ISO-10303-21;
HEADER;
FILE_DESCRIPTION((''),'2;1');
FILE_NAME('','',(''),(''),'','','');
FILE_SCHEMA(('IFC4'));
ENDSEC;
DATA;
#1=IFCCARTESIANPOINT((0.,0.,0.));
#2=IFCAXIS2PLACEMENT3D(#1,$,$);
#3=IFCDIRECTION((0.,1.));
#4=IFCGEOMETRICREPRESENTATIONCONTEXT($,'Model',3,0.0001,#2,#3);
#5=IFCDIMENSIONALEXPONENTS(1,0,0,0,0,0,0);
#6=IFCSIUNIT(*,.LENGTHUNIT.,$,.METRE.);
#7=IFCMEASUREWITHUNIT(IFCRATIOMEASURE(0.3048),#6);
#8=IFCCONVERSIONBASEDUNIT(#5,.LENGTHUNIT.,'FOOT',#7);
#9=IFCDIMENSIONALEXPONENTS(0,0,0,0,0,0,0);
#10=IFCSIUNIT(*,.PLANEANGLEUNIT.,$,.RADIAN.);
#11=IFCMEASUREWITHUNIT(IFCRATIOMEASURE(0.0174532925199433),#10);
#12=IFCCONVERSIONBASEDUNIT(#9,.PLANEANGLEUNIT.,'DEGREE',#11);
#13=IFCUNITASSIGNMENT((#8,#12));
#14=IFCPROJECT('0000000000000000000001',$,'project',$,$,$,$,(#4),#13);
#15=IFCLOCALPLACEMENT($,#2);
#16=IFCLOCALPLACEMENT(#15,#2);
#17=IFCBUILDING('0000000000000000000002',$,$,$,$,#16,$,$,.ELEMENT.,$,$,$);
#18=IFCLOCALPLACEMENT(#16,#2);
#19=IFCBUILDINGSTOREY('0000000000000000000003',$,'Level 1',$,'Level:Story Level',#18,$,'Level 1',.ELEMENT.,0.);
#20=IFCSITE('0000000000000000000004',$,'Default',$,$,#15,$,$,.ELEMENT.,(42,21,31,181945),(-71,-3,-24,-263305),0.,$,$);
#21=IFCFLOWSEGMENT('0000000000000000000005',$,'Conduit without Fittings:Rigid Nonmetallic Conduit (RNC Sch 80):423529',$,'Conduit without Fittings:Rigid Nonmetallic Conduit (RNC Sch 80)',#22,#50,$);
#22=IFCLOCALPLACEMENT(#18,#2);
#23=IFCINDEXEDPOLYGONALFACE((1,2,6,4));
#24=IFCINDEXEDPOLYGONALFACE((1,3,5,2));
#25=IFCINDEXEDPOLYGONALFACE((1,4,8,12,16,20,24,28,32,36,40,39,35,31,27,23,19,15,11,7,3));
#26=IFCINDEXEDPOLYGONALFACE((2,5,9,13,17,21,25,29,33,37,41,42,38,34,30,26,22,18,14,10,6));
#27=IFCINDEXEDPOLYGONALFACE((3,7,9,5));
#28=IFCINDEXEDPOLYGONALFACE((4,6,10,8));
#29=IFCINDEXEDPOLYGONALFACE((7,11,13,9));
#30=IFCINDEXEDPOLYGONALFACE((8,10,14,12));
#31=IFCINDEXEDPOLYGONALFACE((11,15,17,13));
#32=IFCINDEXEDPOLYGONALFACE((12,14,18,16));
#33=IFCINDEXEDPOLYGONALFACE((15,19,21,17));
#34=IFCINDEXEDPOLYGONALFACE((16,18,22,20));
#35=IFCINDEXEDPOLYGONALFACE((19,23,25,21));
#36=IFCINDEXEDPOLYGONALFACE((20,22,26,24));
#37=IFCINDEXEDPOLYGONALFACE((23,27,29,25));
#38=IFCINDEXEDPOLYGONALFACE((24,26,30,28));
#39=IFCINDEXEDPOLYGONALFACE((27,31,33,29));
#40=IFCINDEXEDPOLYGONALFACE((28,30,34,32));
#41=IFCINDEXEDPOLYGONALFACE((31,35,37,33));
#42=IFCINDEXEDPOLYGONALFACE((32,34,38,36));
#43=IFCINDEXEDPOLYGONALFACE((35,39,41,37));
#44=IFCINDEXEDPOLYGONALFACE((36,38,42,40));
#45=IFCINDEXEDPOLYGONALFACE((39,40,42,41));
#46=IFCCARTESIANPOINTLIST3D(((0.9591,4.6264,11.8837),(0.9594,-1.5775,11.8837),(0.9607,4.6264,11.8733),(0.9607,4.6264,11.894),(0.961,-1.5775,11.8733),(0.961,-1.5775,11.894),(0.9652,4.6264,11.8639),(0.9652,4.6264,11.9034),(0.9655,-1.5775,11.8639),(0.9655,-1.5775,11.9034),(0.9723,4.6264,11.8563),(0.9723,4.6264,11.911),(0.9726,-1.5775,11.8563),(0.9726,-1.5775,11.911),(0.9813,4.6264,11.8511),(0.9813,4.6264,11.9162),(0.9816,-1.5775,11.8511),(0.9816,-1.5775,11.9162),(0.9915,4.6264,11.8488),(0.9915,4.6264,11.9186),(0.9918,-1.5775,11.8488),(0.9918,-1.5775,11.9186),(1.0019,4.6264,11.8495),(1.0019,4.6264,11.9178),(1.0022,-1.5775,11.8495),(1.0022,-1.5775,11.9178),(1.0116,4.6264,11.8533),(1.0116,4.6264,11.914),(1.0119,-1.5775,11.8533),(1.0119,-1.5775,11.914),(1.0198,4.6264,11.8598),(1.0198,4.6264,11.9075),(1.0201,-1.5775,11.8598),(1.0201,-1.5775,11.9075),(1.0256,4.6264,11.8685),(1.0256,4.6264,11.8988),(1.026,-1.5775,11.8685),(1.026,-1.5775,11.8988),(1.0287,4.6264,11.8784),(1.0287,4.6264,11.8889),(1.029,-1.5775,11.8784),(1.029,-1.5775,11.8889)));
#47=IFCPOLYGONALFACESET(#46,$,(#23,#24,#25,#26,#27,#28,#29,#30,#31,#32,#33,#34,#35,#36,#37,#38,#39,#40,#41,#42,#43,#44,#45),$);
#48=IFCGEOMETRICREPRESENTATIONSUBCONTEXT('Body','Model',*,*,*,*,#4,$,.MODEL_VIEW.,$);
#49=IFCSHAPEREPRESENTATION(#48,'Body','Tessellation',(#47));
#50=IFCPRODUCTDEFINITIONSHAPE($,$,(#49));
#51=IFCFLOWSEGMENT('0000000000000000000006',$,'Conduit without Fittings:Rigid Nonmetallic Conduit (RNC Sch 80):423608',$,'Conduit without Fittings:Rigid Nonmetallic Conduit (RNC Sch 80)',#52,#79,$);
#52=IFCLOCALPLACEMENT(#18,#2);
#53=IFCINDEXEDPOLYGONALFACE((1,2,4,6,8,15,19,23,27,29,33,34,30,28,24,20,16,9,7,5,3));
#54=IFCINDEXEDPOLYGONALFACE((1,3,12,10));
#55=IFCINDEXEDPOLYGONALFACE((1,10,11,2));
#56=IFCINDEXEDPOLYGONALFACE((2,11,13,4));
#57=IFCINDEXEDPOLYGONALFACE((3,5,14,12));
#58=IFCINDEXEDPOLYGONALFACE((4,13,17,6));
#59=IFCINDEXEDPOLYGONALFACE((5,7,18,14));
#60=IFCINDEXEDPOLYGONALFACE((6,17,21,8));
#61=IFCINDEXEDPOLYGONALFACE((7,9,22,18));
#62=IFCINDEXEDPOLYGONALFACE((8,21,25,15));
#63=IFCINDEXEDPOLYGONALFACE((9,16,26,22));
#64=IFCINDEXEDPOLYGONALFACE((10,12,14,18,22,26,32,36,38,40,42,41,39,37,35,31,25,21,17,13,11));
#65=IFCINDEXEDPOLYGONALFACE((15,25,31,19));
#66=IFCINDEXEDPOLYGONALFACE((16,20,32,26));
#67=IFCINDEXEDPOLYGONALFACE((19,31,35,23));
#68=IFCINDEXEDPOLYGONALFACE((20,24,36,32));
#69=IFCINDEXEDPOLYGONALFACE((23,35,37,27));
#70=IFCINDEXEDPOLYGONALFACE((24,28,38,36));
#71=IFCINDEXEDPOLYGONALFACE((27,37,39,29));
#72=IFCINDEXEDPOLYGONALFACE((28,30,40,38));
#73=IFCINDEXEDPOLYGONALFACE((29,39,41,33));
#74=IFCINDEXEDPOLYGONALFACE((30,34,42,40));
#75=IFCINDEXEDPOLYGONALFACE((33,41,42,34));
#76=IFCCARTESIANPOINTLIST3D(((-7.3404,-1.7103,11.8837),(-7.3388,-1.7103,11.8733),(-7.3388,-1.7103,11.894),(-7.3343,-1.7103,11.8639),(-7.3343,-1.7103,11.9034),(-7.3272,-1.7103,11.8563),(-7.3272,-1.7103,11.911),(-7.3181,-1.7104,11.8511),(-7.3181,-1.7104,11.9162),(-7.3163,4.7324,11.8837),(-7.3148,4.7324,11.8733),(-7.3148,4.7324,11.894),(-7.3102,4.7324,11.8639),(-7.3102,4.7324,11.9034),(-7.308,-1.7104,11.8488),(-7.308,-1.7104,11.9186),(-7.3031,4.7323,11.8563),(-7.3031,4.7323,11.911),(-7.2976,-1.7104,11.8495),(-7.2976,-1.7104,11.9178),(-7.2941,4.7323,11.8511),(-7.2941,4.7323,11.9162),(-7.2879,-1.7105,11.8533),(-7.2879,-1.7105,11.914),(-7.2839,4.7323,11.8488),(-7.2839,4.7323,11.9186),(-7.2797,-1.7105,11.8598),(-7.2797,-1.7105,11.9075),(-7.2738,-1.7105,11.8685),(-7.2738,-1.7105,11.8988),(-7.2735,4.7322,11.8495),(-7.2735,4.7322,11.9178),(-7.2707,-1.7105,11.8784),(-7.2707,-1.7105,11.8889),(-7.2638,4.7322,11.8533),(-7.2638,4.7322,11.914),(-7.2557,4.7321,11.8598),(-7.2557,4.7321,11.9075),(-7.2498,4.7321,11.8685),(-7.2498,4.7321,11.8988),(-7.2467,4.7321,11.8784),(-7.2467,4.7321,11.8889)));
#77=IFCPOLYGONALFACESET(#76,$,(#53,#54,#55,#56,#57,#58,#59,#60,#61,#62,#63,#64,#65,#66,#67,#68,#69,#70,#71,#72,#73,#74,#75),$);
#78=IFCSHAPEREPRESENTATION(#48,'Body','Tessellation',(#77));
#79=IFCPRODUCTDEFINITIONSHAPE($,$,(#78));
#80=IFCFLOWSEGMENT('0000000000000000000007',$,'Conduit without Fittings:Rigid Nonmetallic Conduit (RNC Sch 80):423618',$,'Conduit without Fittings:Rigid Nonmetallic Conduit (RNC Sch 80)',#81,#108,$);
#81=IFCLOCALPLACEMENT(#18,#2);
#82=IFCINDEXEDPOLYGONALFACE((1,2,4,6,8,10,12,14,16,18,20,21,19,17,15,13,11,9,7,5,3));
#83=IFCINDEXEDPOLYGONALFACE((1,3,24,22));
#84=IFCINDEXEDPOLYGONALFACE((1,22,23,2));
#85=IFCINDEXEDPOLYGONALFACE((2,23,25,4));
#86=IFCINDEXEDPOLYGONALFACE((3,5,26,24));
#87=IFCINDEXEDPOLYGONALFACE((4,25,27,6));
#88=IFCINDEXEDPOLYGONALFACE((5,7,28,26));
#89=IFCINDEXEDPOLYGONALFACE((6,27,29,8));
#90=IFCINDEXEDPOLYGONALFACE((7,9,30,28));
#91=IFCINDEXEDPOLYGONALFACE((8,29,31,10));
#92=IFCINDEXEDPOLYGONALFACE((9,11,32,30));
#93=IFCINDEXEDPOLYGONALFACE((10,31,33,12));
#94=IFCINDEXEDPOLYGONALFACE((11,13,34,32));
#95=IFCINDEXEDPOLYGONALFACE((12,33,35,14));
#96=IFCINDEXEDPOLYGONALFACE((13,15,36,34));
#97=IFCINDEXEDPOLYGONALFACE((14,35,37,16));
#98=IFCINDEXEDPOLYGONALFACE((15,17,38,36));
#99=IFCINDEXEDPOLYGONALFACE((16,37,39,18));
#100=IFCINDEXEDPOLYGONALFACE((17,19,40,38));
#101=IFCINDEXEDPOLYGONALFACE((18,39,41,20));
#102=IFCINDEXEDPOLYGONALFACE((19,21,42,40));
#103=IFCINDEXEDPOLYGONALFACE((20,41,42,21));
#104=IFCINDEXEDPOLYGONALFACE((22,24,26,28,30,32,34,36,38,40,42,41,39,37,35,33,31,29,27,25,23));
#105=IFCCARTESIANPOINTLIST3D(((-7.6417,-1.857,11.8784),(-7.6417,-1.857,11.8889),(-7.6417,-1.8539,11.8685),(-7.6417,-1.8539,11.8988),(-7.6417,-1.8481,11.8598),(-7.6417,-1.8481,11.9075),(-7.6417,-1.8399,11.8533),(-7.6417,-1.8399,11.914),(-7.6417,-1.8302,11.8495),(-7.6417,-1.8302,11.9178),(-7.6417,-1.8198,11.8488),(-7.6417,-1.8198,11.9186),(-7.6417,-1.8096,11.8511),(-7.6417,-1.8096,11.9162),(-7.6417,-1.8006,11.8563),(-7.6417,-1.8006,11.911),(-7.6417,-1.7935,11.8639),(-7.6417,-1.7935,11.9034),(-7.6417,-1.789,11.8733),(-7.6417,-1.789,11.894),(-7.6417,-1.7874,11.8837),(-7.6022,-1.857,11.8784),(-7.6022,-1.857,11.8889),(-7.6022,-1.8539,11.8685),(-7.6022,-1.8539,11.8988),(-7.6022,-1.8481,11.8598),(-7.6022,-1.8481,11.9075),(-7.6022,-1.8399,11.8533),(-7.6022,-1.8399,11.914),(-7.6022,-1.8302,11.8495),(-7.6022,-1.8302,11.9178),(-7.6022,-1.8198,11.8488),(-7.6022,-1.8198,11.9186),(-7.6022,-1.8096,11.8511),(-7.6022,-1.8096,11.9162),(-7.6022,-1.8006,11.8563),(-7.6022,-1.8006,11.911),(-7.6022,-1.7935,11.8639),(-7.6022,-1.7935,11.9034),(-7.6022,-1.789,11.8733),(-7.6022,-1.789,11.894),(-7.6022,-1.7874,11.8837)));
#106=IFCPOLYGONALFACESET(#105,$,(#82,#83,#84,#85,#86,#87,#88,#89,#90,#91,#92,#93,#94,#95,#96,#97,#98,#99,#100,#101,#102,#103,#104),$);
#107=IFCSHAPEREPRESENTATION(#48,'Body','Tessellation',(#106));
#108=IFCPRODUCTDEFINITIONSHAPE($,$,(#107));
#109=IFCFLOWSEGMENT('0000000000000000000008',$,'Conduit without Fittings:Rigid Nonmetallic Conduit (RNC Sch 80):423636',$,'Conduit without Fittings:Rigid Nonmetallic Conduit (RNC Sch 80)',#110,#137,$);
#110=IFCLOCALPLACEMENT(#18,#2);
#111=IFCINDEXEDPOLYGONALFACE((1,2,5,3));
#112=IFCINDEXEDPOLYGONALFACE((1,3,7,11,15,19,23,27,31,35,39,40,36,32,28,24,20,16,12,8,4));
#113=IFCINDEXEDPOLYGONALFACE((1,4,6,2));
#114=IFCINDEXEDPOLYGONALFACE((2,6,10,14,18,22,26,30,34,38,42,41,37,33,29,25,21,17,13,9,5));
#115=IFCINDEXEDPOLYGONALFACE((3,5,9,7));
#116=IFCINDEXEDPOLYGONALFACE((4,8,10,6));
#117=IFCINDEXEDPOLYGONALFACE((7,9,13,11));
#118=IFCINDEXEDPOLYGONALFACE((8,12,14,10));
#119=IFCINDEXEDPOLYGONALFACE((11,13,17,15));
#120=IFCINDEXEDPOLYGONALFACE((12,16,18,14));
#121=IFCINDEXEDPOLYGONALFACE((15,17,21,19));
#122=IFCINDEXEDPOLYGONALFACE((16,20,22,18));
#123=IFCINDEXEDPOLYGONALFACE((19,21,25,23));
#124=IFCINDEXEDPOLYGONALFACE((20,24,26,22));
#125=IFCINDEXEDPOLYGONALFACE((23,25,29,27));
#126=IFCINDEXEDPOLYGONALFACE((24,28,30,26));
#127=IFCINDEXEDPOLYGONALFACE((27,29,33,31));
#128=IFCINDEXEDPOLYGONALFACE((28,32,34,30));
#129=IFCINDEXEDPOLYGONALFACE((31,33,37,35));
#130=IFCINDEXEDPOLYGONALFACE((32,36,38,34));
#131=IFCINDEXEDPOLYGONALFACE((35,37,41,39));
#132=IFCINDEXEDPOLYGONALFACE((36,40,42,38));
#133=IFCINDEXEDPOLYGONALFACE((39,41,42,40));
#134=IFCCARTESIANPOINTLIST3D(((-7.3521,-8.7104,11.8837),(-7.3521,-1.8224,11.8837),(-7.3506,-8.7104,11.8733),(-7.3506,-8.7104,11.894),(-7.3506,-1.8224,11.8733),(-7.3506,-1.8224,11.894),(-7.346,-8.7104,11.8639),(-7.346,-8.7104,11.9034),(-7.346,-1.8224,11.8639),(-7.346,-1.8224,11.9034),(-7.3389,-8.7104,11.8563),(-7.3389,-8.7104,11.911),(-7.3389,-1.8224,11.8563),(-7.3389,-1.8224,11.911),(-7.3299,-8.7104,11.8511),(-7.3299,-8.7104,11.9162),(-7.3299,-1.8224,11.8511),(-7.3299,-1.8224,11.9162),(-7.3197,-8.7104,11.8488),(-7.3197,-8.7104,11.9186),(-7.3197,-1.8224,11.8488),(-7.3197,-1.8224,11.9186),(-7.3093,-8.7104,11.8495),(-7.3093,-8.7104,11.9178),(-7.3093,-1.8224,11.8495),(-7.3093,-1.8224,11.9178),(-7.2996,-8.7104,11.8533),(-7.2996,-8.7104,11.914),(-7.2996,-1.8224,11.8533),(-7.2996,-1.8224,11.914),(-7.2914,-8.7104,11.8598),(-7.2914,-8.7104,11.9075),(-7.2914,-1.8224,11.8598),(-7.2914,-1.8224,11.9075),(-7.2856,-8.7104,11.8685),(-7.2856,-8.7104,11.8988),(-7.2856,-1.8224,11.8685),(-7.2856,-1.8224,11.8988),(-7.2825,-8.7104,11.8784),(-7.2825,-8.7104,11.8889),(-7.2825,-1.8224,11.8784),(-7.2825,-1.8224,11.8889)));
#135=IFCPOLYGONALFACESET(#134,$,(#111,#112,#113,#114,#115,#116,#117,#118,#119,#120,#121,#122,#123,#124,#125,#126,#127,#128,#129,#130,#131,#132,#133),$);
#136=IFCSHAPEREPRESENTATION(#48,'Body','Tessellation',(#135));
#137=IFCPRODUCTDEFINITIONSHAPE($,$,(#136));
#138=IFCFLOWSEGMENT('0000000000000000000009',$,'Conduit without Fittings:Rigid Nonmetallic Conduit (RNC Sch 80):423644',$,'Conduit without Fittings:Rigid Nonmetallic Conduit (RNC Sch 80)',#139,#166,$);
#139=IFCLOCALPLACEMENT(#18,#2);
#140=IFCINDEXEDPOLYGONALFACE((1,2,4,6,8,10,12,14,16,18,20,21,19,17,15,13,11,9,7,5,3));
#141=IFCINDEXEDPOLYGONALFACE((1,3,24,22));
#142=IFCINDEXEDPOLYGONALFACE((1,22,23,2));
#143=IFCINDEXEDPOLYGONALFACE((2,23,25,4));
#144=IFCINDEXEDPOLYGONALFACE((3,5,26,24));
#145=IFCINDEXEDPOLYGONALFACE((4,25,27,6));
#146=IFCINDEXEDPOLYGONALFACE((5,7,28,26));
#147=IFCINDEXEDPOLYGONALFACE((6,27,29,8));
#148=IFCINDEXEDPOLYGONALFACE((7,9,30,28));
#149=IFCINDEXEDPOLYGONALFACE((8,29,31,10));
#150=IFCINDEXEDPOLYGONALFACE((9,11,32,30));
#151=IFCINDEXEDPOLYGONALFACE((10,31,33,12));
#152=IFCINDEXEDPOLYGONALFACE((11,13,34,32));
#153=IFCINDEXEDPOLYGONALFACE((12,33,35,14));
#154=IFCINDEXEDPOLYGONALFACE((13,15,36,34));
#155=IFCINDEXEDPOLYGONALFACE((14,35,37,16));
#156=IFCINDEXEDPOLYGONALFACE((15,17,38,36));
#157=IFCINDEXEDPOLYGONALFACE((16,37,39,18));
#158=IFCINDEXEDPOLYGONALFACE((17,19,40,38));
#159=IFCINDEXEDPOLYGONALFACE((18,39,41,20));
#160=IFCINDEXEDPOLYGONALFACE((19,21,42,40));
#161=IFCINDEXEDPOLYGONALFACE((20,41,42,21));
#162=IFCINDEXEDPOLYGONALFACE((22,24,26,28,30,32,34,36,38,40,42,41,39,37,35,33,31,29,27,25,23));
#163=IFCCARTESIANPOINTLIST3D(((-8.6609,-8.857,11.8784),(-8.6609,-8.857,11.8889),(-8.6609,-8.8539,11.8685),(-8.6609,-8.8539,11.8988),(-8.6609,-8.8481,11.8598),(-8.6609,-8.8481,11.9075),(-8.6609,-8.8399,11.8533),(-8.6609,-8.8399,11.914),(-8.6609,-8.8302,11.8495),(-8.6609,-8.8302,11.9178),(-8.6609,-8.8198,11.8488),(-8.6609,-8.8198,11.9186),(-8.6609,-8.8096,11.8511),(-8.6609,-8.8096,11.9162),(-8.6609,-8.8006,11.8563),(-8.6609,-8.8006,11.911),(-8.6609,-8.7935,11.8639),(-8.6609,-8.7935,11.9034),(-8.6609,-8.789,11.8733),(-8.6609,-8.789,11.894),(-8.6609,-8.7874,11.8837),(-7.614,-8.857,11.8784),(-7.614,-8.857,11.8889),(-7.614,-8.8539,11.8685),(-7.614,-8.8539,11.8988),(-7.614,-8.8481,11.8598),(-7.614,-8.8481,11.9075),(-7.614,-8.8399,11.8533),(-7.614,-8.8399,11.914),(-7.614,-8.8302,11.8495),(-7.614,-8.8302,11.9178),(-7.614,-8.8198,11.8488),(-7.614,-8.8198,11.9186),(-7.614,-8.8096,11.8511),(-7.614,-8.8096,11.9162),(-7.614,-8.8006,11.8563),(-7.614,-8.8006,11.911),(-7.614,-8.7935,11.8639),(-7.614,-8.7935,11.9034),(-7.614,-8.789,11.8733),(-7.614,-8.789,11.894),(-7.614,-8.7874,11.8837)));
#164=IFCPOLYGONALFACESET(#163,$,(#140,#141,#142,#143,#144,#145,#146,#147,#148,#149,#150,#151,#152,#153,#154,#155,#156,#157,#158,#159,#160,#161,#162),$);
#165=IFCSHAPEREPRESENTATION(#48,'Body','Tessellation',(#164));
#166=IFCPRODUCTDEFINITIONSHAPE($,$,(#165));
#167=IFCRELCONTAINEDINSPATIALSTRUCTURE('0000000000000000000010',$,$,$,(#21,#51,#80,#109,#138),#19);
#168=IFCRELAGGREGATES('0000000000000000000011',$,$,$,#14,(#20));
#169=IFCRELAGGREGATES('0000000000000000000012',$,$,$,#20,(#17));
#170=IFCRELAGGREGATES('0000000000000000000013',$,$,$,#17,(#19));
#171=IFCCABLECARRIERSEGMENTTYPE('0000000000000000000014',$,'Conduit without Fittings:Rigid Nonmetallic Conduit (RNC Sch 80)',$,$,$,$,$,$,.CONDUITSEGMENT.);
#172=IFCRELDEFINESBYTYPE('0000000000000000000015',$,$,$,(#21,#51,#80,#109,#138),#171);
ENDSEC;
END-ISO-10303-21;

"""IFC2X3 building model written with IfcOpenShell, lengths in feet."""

from ifc_helpers import new_model, entity, si_unit, converted_unit, direction, frame, frame_2d, origin, origin_2d_with_axis, place, context, subcontext, project, spatial, circle, extrude, type_object, element, save


model = new_model("IFC2X3")

# Units and contexts
model_context = context("Model", 3, precision=0.0001, world=origin(), true_north=direction((0.0, 1.0)))
body_context = subcontext(model_context, "Body", "Model", "MODEL_VIEW")
ifc_project = project(units=[converted_unit("LENGTHUNIT", "FOOT", entity("IfcRatioMeasure", 0.3048), si_unit("LENGTHUNIT", "METRE"), dimensions=[1, 0, 0, 0, 0, 0, 0]), converted_unit("PLANEANGLEUNIT", "DEGREE", entity("IfcRatioMeasure", 0.0174532925199433), si_unit("PLANEANGLEUNIT", "RADIAN"), dimensions=[0, 0, 0, 0, 0, 0, 0])], contexts=[model_context])

# Site, building, storey
site_placement = place(None, origin())
site = spatial("IfcSite", under=ifc_project, at=site_placement, Name="Default", CompositionType="ELEMENT", RefLatitude=(42, 21, 31, 181945), RefLongitude=(-71, -3, -24, -263305), RefElevation=0.0)
building_placement = place(site_placement, origin())
building = spatial("IfcBuilding", under=site, at=building_placement, CompositionType="ELEMENT")
storey_placement = place(building_placement, origin())
storey = spatial("IfcBuildingStorey", under=building, at=storey_placement, Name="Level 1", ObjectType="Level:Story Level", LongName="Level 1", CompositionType="ELEMENT", Elevation=0.0)

# Flow segments
cable_carrier_segment_type = type_object("IfcCableCarrierSegmentType", Name="Conduit without Fittings:Rigid Nonmetallic Conduit (RNC Sch 80)", PredefinedType="CONDUITSEGMENT")
flow_segment_1_placement = place(storey_placement, origin())
element("IfcFlowSegment", 1, at=flow_segment_1_placement, inside=storey, type_object=cable_carrier_segment_type, Name="Conduit without Fittings:Rigid Nonmetallic Conduit (RNC Sch 80):423529", ObjectType="Conduit without Fittings:Rigid Nonmetallic Conduit (RNC Sch 80)", context=body_context, shape_type="SweptSolid", body=[
    extrude(circle(Radius=0.035, at=origin_2d_with_axis()), frame((0.9941, 4.6264, 11.8837), z_axis=(0.000051, -1.0, 0.0), x_axis=(-1.0, -0.000051, 0.0)), (0.0, 0.0, 1.0), 6.2039),
])
flow_segment_2_placement = place(storey_placement, origin())
element("IfcFlowSegment", 2, at=flow_segment_2_placement, inside=storey, type_object=cable_carrier_segment_type, Name="Conduit without Fittings:Rigid Nonmetallic Conduit (RNC Sch 80):423608", ObjectType="Conduit without Fittings:Rigid Nonmetallic Conduit (RNC Sch 80)", context=body_context, shape_type="SweptSolid", body=[
    extrude(circle(Radius=0.035, at=frame_2d((0.0, 0.0), x_axis=(1.0, 0.0))), frame((-7.3054, -1.7104, 11.8837), z_axis=(0.00373, 0.999993, 0.0), x_axis=(-0.999993, 0.00373, 0.0)), (0.0, 0.0, 1.0), 6.4427),
])
flow_segment_3_placement = place(storey_placement, origin())
element("IfcFlowSegment", 3, at=flow_segment_3_placement, inside=storey, type_object=cable_carrier_segment_type, Name="Conduit without Fittings:Rigid Nonmetallic Conduit (RNC Sch 80):423618", ObjectType="Conduit without Fittings:Rigid Nonmetallic Conduit (RNC Sch 80)", context=body_context, shape_type="SweptSolid", body=[
    extrude(circle(Radius=0.035, at=frame_2d((0.0, 0.0), x_axis=(1.0, 0.0))), frame((-7.6417, -1.8224, 11.8837), z_axis=(1.0, 0.0, 0.0), x_axis=(0.0, 1.0, 0.0)), (0.0, 0.0, 1.0), 0.0394),
])
flow_segment_4_placement = place(storey_placement, origin())
element("IfcFlowSegment", 4, at=flow_segment_4_placement, inside=storey, type_object=cable_carrier_segment_type, Name="Conduit without Fittings:Rigid Nonmetallic Conduit (RNC Sch 80):423636", ObjectType="Conduit without Fittings:Rigid Nonmetallic Conduit (RNC Sch 80)", context=body_context, shape_type="SweptSolid", body=[
    extrude(circle(Radius=0.035, at=frame_2d((0.0, 0.0), x_axis=(1.0, 0.0))), frame((-7.3171, -8.7104, 11.8837), z_axis=(0.0, 1.0, 0.0), x_axis=(-1.0, 0.0, 0.0)), (0.0, 0.0, 1.0), 6.888),
])
flow_segment_5_placement = place(storey_placement, origin())
element("IfcFlowSegment", 5, at=flow_segment_5_placement, inside=storey, type_object=cable_carrier_segment_type, Name="Conduit without Fittings:Rigid Nonmetallic Conduit (RNC Sch 80):423644", ObjectType="Conduit without Fittings:Rigid Nonmetallic Conduit (RNC Sch 80)", context=body_context, shape_type="SweptSolid", body=[
    extrude(circle(Radius=0.035, at=frame_2d((0.0, 0.0), x_axis=(1.0, 0.0))), frame((-8.6609, -8.8224, 11.8837), z_axis=(1.0, 0.0, 0.0), x_axis=(0.0, 1.0, 0.0)), (0.0, 0.0, 1.0), 1.0469),
])

save(model, "model.ifc")
